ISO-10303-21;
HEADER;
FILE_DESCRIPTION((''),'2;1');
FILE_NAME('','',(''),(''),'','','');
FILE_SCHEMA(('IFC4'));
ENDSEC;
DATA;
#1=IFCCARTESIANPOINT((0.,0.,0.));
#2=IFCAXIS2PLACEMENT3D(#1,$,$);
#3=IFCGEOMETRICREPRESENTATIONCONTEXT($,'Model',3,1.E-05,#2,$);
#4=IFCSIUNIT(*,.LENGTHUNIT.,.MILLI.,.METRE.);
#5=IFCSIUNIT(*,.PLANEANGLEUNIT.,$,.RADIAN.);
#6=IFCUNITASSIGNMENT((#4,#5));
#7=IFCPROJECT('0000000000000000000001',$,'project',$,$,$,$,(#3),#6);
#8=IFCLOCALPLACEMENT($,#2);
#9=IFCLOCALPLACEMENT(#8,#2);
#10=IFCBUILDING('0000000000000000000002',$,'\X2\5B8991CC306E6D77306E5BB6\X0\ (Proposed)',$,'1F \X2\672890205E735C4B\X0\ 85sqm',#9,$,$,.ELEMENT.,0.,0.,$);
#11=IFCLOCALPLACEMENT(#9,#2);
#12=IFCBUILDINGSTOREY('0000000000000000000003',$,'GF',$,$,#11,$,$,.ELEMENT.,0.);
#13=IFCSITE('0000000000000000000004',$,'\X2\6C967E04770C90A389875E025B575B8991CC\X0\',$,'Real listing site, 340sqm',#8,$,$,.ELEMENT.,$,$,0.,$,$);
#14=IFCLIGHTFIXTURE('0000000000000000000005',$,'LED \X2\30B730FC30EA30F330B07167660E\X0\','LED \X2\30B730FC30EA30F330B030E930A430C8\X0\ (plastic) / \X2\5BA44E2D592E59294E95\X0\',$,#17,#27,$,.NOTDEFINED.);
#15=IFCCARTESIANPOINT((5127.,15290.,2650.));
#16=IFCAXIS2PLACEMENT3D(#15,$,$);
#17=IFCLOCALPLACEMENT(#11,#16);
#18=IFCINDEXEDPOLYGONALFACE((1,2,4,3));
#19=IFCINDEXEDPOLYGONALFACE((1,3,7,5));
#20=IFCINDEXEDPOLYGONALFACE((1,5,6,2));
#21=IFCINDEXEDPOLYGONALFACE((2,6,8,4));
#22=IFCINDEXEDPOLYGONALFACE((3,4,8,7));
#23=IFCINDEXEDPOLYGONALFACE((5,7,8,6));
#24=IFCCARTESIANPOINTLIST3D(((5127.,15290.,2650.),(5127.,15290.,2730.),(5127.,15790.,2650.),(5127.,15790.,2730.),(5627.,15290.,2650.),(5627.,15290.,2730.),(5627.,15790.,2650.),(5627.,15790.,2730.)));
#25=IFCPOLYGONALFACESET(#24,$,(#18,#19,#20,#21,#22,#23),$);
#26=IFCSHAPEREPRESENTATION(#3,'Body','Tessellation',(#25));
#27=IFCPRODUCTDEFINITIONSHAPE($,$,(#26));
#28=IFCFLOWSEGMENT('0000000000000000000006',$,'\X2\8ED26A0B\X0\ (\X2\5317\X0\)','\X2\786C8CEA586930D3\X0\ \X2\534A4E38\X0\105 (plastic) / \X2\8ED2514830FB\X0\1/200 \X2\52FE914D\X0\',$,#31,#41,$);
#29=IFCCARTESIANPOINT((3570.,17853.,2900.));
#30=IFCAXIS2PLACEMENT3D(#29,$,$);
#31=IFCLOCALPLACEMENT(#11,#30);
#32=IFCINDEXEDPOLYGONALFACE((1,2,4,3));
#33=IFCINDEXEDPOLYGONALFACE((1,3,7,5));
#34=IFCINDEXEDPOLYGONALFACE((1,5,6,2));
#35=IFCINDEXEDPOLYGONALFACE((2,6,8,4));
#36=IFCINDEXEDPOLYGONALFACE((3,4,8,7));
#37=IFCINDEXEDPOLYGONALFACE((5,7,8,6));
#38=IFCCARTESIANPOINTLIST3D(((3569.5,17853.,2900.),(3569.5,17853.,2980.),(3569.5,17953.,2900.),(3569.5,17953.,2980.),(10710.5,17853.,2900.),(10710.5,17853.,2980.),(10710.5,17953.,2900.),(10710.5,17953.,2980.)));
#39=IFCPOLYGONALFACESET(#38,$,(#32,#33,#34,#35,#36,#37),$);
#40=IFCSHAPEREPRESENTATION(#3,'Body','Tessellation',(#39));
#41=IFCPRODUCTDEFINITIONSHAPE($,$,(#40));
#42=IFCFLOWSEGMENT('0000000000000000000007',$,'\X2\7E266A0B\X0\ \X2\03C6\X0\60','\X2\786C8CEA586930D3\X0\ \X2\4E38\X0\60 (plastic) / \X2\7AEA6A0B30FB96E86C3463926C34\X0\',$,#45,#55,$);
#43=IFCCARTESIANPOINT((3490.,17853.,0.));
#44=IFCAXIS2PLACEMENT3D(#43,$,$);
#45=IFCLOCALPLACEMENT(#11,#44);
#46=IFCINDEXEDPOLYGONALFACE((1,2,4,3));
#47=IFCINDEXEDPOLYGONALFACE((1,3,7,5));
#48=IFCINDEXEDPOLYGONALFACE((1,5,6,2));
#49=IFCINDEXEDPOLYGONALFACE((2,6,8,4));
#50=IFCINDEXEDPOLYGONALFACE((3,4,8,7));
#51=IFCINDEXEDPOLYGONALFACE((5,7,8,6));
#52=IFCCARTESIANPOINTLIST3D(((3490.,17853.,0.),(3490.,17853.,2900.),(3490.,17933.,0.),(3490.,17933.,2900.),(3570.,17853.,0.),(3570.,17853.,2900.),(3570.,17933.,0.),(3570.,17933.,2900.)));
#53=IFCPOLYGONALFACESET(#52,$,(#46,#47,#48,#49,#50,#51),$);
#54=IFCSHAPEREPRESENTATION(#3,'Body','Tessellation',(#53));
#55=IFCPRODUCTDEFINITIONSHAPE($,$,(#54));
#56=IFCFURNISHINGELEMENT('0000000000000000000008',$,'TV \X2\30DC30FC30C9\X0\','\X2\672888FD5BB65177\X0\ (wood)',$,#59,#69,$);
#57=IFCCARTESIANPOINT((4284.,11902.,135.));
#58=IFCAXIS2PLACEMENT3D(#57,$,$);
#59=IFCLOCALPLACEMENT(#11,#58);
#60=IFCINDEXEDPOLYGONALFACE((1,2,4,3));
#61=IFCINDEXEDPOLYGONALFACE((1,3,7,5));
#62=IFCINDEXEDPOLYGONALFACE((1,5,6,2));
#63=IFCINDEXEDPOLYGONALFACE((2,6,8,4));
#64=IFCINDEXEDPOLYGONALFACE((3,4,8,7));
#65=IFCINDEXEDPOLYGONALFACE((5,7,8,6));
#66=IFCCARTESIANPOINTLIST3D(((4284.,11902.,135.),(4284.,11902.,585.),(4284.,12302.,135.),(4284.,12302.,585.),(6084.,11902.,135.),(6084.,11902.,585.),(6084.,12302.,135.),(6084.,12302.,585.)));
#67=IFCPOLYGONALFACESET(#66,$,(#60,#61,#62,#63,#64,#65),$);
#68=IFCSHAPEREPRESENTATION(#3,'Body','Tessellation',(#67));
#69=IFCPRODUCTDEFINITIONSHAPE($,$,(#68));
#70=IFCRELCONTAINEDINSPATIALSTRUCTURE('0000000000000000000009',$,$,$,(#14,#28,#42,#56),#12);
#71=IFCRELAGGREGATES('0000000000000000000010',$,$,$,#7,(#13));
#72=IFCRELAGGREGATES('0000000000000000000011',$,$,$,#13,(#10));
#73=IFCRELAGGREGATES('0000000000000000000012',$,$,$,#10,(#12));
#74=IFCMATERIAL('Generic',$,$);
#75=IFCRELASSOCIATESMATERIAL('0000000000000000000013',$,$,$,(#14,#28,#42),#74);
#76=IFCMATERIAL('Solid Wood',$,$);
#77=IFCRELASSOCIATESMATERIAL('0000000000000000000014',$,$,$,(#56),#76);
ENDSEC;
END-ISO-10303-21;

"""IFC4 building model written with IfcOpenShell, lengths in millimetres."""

from ifc_helpers import new_model, si_unit, frame, frame_2d, origin, place, context, project, spatial, rectangle, extrude, material, element, save


model = new_model("IFC4")

# Units and contexts
model_context = context("Model", 3, precision=1e-05, world=origin())
ifc_project = project(units=[si_unit("LENGTHUNIT", "METRE", prefix="MILLI"), si_unit("PLANEANGLEUNIT", "RADIAN")], contexts=[model_context])

# Site, building, storey
site_placement = place(None, origin())
site = spatial("IfcSite", under=ifc_project, at=site_placement, Name="沖縄県那覇市字安里", ObjectType="Real listing site, 340sqm", CompositionType="ELEMENT", RefElevation=0.0)
building_placement = place(site_placement, origin())
building = spatial("IfcBuilding", under=site, at=building_placement, Name="安里の海の家 (Proposed)", ObjectType="1F 木造平屋 85sqm", CompositionType="ELEMENT", ElevationOfRefHeight=0.0, ElevationOfTerrain=0.0)
storey_placement = place(building_placement, origin())
storey = spatial("IfcBuildingStorey", under=building, at=storey_placement, Name="GF", CompositionType="ELEMENT", Elevation=0.0)

# Shared definitions
ifc_material_1 = material(Name="Solid Wood")

# Shared definitions
ifc_material_2 = material(Name="Generic")

# Light fixture
light_fixture_placement = place(storey_placement, frame((5127.0, 15290.0, 2650.0)))
element("IfcLightFixture", 1, at=light_fixture_placement, inside=storey, material=ifc_material_2, Name="LED シーリング照明", Description="LED シーリングライト (plastic) / 室中央天井", PredefinedType="NOTDEFINED", context=model_context, shape_type="SweptSolid", body=[
    extrude(rectangle(XDim=500.0, YDim=500.0, at=frame_2d((250.0, 250.0))), frame((5127.0, 15290.0, 2650.0)), (0.0, 0.0, 1.0), 80.0),
])

# Flow segments
flow_segment_1_placement = place(storey_placement, frame((3570.0, 17853.0, 2900.0)))
element("IfcFlowSegment", 2, at=flow_segment_1_placement, inside=storey, material=ifc_material_2, Name="軒樋 (北)", Description="硬質塩ビ 半丸105 (plastic) / 軒先・1/200 勾配", context=model_context, shape_type="SweptSolid", body=[
    extrude(rectangle(XDim=7141.0, YDim=100.0, at=frame_2d((3570.0, 50.0))), frame((3570.0, 17853.0, 2900.0)), (0.0, 0.0, 1.0), 80.0),
])
flow_segment_2_placement = place(storey_placement, frame((3490.0, 17853.0, 0.0)))
element("IfcFlowSegment", 3, at=flow_segment_2_placement, inside=storey, material=ifc_material_2, Name="縦樋 φ60", Description="硬質塩ビ 丸60 (plastic) / 竪樋・雨水排水", context=model_context, shape_type="SweptSolid", body=[
    extrude(rectangle(XDim=80.0, YDim=80.0, at=frame_2d((40.0, 40.0))), frame((3490.0, 17853.0, 0.0)), (0.0, 0.0, 1.0), 2900.0),
])

# Furnishing element
furnishing_placement = place(storey_placement, frame((4284.0, 11902.0, 135.0)))
element("IfcFurnishingElement", 4, at=furnishing_placement, inside=storey, material=ifc_material_1, Name="TV ボード", Description="木製家具 (wood)", context=model_context, shape_type="SweptSolid", body=[
    extrude(rectangle(XDim=1800.0, YDim=400.0, at=frame_2d((900.0, 200.0))), frame((4284.0, 11902.0, 135.0)), (0.0, 0.0, 1.0), 450.0),
])

save(model, "model.ifc")
